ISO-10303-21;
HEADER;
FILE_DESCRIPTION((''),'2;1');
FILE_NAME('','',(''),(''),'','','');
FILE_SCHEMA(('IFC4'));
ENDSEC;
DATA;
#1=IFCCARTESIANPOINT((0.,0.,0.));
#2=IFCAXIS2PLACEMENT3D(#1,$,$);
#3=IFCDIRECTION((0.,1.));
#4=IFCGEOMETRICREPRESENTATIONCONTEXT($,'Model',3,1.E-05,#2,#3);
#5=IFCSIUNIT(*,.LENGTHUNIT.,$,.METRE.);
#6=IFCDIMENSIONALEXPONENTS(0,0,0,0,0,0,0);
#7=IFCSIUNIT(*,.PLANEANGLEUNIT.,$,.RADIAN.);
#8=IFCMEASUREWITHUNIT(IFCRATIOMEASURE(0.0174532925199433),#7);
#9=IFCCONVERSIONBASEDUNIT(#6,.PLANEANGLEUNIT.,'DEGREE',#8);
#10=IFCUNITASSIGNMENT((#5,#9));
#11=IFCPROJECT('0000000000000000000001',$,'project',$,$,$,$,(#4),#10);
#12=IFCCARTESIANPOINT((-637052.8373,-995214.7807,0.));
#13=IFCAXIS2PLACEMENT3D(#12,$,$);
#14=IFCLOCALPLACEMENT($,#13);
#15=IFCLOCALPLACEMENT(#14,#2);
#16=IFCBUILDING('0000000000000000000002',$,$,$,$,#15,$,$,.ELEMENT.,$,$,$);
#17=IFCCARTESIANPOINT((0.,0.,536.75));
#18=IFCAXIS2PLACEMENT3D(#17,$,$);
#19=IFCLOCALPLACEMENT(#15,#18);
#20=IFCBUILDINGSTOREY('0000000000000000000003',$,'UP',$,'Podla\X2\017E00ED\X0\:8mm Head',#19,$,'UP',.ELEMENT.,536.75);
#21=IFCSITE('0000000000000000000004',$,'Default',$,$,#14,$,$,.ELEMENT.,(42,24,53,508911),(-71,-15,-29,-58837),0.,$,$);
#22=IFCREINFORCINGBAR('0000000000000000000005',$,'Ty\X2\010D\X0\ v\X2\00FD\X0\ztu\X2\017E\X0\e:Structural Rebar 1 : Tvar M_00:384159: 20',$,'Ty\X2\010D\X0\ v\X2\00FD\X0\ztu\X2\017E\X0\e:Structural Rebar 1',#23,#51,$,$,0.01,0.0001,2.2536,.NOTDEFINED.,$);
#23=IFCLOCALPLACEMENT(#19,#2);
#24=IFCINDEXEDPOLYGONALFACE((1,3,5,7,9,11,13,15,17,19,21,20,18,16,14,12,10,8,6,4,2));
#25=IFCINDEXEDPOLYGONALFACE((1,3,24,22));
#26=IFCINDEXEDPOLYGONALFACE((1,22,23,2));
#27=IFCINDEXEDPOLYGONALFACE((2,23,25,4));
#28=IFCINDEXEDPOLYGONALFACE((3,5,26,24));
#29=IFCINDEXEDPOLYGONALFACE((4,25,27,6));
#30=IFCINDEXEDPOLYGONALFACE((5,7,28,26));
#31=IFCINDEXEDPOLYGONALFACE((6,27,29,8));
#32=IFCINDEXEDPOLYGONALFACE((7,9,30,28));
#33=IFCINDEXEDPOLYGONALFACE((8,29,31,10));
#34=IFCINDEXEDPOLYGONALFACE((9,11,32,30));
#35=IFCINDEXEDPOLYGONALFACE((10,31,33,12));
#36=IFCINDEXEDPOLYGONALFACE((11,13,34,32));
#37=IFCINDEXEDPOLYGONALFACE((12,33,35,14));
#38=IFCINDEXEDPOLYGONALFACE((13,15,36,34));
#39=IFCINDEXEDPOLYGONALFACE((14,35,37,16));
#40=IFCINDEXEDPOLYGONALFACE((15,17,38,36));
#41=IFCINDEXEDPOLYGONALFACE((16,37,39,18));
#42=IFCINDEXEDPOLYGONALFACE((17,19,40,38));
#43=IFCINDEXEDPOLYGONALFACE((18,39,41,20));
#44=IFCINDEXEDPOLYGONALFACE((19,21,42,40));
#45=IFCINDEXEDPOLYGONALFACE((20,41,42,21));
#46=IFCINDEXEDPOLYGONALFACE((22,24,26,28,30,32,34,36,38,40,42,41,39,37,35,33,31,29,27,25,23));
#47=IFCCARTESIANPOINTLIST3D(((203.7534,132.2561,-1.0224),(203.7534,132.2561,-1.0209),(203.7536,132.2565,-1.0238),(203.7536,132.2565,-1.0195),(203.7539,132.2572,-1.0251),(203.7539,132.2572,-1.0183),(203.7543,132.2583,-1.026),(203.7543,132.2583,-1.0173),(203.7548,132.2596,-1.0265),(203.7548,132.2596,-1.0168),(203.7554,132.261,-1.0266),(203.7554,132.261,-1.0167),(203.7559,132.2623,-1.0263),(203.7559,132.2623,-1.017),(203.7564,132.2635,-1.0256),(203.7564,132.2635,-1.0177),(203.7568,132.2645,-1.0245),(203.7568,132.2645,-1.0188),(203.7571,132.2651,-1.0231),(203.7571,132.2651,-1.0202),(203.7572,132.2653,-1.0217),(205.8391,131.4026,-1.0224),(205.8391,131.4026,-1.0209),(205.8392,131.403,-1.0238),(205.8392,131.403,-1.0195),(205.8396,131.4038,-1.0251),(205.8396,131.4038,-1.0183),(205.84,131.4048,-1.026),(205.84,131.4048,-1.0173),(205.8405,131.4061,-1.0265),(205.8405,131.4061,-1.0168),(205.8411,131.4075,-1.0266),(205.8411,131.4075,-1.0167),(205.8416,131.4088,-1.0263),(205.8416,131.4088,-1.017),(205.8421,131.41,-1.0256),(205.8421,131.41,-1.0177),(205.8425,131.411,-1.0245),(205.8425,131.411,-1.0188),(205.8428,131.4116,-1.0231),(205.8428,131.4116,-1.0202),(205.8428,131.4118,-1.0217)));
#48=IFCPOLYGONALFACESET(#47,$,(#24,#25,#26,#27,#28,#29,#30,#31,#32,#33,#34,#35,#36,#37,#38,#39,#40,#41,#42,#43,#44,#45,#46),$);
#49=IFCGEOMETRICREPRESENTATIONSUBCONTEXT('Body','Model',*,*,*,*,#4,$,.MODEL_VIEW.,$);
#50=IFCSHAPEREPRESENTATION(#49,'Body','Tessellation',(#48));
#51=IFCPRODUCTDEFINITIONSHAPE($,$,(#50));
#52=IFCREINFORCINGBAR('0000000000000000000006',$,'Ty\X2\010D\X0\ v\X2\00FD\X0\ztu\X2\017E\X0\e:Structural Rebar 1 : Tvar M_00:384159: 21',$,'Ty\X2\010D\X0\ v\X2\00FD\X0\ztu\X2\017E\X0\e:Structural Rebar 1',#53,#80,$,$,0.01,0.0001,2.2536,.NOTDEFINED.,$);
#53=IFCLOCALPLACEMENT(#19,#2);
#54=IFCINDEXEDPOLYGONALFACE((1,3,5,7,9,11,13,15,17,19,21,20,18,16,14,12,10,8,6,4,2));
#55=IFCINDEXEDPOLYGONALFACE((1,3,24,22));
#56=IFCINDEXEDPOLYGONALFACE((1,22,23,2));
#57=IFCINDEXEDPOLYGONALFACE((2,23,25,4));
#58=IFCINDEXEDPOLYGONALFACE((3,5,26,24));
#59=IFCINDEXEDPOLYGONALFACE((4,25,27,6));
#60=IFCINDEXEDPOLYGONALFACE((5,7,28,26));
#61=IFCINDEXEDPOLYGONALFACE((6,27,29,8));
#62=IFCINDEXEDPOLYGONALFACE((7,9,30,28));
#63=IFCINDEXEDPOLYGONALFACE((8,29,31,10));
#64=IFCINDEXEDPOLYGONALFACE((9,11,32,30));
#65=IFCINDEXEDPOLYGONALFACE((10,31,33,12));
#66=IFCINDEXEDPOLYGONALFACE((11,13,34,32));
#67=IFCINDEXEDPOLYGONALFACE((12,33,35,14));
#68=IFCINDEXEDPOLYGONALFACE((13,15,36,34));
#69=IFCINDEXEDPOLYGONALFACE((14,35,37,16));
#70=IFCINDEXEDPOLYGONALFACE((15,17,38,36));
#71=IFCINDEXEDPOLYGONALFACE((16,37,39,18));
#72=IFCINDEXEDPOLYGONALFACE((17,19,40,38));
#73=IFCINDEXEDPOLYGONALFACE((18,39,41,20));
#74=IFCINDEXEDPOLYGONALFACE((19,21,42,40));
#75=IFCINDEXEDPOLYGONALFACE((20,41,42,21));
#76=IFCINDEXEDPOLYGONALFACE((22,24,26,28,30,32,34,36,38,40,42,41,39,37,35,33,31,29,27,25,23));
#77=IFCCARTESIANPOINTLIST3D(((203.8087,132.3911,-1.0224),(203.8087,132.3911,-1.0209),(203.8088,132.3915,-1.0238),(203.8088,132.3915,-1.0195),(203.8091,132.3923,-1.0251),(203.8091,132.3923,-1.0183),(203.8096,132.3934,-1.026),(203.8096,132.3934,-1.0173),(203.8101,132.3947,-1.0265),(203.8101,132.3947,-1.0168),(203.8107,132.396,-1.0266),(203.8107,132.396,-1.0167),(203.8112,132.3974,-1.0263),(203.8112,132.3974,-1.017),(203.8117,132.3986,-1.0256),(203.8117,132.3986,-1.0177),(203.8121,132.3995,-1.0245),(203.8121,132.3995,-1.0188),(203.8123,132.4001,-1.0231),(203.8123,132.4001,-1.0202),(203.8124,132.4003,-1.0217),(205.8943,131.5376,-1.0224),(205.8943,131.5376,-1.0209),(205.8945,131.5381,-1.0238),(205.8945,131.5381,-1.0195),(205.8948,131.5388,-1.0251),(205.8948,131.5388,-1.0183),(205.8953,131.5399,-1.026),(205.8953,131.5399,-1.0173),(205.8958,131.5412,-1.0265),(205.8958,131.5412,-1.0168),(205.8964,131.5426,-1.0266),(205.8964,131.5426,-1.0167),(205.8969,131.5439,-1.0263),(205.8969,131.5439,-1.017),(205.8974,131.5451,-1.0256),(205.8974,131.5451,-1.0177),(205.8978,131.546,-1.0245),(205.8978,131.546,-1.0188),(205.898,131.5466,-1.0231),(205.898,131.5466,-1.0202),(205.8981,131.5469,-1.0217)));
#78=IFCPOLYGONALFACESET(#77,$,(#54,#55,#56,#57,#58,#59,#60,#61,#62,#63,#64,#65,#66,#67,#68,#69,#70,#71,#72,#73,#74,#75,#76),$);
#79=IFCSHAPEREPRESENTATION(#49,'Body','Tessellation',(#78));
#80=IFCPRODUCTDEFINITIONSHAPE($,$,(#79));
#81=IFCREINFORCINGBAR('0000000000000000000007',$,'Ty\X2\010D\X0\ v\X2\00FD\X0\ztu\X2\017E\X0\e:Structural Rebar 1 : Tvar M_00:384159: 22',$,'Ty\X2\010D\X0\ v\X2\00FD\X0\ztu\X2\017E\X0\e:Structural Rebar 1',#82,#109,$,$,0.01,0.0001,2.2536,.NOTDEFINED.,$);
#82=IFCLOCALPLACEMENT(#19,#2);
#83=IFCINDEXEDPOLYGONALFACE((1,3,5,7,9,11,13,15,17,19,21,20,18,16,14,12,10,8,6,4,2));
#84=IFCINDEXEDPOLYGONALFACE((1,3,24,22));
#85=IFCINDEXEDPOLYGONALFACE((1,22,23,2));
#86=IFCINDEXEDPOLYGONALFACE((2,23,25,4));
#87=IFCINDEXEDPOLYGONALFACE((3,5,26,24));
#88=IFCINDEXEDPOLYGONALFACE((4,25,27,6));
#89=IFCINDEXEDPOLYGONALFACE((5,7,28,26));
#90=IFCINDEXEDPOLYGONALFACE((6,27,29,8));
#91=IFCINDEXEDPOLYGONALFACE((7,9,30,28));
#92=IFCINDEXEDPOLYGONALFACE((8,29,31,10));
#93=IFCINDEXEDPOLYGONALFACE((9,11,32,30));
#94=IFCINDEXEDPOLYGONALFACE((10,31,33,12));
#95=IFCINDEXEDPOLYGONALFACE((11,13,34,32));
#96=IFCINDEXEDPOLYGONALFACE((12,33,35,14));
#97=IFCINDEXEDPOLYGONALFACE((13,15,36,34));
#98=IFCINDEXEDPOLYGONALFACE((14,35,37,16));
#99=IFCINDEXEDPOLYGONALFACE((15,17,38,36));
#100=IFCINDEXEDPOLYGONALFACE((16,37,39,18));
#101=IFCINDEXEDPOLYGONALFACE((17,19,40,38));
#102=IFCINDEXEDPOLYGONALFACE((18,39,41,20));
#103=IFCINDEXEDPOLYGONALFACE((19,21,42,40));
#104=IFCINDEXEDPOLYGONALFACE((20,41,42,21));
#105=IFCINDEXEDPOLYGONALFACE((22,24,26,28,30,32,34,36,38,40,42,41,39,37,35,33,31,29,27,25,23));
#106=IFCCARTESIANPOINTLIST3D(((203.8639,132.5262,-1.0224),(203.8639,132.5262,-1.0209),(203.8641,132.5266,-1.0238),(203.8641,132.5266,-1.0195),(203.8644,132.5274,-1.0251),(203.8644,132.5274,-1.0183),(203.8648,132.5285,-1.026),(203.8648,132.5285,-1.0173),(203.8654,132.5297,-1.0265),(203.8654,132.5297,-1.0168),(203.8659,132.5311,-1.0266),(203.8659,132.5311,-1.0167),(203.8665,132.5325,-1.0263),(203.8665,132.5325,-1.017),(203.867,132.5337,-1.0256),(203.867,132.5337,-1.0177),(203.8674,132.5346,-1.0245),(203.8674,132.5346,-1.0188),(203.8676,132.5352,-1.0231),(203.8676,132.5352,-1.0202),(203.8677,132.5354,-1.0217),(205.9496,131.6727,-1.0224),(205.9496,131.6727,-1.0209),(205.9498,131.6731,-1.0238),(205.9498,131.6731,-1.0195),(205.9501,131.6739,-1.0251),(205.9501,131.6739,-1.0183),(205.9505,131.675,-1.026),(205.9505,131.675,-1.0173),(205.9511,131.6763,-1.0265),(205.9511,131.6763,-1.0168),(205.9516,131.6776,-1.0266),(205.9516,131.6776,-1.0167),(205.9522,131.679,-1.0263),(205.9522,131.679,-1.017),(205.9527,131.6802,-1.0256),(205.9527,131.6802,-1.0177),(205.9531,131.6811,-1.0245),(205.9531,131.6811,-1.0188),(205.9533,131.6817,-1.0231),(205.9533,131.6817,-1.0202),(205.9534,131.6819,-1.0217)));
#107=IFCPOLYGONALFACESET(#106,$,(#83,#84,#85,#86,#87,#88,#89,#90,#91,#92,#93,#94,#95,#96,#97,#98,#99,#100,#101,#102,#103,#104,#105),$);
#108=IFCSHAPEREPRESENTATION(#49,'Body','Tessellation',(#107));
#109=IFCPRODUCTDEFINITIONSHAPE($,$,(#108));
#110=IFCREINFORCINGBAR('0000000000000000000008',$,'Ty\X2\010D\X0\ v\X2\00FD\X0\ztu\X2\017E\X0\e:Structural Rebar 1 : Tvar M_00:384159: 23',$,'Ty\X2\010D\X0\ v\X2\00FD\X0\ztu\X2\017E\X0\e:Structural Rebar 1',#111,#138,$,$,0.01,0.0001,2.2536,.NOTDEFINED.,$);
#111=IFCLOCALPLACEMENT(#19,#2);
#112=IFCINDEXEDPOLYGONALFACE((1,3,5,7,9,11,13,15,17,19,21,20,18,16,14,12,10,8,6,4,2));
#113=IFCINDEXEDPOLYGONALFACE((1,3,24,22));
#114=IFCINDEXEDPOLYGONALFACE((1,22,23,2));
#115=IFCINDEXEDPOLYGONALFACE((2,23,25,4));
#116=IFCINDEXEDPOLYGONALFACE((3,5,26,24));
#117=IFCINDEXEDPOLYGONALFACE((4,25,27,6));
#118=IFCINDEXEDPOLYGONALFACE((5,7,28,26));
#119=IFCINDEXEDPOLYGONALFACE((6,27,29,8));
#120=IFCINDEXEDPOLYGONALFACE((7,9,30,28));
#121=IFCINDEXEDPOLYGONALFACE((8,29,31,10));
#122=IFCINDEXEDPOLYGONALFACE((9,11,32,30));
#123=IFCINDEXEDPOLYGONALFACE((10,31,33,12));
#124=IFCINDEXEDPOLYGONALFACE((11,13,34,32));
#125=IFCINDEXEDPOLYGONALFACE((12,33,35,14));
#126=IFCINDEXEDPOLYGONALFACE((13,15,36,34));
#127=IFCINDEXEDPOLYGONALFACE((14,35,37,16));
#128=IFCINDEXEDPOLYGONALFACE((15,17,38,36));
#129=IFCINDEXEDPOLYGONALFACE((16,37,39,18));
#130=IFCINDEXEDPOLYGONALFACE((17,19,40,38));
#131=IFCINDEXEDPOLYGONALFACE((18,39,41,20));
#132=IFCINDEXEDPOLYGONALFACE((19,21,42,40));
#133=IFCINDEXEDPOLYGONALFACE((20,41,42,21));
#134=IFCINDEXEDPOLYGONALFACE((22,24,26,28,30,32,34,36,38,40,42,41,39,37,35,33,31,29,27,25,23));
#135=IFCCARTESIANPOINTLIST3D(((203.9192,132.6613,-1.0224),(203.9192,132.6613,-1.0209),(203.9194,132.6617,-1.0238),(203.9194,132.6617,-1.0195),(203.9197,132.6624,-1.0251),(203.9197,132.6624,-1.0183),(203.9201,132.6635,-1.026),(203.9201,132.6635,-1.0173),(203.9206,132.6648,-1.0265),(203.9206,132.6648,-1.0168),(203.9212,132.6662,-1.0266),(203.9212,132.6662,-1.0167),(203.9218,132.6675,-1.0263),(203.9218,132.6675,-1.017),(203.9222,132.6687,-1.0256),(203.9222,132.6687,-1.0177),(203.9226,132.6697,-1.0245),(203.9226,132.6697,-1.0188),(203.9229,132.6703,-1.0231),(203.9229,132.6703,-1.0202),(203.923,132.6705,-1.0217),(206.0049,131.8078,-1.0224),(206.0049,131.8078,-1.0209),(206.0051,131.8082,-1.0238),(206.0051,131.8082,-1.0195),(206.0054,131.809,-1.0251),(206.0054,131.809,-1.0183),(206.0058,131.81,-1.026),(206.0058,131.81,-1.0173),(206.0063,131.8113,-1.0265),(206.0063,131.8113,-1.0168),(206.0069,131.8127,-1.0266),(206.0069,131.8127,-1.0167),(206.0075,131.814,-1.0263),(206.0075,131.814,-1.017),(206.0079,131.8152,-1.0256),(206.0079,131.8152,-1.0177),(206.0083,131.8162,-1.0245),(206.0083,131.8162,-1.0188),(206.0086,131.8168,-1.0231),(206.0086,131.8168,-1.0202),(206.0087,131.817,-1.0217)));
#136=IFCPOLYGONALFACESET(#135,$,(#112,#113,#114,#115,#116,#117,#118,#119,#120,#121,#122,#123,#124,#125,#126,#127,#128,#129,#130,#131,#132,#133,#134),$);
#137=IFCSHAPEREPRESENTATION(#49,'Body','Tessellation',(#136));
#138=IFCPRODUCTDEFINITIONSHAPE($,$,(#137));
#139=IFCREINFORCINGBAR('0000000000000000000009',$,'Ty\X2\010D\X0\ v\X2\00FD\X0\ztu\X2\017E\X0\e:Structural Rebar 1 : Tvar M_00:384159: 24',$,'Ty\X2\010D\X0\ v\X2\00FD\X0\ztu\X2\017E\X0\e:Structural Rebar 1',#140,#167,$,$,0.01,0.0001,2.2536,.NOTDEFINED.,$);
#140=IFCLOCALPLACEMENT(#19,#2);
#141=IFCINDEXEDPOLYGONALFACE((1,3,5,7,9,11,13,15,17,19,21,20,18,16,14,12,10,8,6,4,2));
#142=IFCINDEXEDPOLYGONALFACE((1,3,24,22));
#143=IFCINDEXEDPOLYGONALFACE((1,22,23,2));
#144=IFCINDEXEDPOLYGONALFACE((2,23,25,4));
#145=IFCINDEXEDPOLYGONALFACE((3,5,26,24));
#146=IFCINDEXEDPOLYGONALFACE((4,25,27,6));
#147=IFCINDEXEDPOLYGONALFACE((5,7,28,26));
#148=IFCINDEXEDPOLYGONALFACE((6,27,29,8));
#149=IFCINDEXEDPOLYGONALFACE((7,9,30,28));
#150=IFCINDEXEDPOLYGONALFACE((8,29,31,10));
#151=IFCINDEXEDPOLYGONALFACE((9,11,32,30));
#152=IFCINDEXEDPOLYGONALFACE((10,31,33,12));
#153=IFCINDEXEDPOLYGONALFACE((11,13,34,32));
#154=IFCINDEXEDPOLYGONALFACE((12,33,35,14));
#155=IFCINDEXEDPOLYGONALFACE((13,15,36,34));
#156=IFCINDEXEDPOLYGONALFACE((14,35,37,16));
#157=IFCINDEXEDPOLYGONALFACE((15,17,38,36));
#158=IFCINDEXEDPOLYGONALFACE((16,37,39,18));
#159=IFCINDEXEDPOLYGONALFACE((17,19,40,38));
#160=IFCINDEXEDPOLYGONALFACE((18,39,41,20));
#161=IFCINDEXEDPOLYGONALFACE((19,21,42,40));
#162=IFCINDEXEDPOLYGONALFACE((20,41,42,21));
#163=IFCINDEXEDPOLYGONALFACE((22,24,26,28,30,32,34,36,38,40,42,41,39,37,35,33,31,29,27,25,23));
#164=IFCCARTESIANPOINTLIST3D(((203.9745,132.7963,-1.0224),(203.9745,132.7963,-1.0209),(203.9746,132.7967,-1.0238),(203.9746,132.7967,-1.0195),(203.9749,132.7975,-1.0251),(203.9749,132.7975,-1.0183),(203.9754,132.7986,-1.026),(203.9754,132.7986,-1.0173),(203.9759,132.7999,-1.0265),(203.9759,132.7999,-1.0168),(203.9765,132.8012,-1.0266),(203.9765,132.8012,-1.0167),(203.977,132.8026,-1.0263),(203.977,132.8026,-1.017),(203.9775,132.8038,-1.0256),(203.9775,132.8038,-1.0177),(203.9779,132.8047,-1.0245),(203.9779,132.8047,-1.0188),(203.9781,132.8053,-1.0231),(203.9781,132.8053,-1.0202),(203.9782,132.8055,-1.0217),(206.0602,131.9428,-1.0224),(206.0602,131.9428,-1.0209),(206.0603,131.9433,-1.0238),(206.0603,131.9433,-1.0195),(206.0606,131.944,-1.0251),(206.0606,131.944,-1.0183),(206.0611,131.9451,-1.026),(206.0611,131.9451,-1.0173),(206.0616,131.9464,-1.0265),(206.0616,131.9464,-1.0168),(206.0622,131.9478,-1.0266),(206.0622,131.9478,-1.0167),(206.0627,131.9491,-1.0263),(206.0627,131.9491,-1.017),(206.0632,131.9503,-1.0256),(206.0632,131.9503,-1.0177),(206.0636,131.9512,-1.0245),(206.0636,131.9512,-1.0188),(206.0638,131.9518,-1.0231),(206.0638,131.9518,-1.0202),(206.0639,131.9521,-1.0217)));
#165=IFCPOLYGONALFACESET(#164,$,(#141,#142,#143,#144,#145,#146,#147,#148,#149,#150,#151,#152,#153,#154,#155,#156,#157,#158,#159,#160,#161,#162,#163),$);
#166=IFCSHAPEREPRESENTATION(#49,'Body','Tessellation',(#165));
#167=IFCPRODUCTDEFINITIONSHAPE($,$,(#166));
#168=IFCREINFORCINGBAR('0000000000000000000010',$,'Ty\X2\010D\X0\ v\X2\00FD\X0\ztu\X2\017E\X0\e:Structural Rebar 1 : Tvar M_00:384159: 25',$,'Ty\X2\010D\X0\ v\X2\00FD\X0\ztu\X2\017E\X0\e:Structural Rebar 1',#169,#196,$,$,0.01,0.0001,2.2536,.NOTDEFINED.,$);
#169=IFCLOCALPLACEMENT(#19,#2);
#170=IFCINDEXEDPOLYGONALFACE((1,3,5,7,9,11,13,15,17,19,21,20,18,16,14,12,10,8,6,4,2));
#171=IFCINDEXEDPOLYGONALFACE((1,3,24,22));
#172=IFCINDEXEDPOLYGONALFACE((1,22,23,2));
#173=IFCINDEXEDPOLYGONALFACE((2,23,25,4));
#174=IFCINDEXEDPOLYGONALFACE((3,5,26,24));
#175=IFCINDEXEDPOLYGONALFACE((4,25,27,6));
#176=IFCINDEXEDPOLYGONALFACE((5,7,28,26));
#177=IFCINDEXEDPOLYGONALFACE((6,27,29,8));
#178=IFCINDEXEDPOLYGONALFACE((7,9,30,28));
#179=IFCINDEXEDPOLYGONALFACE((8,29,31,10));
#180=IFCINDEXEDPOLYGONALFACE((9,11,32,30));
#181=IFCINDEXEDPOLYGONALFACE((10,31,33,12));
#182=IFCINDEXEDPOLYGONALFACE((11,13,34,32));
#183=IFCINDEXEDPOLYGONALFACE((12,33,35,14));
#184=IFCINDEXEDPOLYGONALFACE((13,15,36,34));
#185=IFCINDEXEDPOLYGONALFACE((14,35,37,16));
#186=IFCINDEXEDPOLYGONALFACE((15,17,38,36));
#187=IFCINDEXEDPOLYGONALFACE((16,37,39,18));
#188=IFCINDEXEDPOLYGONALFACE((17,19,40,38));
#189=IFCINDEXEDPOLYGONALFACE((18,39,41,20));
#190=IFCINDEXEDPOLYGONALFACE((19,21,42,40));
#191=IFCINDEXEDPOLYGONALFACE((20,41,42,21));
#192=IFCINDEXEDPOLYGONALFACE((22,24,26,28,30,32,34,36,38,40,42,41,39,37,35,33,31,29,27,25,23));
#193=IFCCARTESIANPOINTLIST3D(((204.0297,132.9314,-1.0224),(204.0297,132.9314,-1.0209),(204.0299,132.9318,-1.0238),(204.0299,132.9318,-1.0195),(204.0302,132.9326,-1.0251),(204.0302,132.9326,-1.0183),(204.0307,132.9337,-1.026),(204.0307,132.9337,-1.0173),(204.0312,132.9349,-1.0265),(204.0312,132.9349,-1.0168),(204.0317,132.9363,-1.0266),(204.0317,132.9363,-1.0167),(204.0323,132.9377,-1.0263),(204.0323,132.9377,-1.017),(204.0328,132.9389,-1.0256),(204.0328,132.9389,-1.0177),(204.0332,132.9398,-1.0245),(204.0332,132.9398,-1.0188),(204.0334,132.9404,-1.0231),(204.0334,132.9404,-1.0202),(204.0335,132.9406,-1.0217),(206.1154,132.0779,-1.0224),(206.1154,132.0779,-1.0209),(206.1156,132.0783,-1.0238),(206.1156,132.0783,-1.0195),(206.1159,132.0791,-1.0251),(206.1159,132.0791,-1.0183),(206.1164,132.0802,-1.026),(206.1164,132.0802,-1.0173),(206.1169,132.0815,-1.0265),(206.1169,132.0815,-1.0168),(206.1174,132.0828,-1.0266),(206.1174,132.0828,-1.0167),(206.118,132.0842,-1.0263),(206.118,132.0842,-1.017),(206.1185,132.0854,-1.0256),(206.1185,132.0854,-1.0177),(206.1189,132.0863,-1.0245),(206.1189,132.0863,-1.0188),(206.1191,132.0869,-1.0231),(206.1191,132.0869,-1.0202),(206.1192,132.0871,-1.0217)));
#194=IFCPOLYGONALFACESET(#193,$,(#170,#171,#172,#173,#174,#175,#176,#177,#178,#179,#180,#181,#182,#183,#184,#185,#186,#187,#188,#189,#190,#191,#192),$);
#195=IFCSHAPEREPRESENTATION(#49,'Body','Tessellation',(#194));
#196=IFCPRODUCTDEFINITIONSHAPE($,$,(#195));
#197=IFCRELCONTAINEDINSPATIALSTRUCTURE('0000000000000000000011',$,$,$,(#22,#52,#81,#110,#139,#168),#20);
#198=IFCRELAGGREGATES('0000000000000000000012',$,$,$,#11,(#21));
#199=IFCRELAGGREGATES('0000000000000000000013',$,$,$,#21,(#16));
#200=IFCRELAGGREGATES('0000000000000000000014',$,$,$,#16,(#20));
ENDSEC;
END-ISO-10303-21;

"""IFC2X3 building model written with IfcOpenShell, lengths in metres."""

from ifc_helpers import new_model, entity, si_unit, converted_unit, direction, frame, origin, place, context, subcontext, project, spatial, element, save


model = new_model("IFC2X3")

# Units and contexts
model_context = context("Model", 3, precision=1e-05, world=origin(), true_north=direction((0.0, 1.0)))
body_context = subcontext(model_context, "Body", "Model", "MODEL_VIEW")
ifc_project = project(units=[si_unit("LENGTHUNIT", "METRE"), converted_unit("PLANEANGLEUNIT", "DEGREE", entity("IfcRatioMeasure", 0.0174532925199433), si_unit("PLANEANGLEUNIT", "RADIAN"), dimensions=[0, 0, 0, 0, 0, 0, 0])], contexts=[model_context])

# Site, building, storey
site_placement = place(None, frame((-637052.8373, -995214.7807, 0.0)))
site = spatial("IfcSite", under=ifc_project, at=site_placement, Name="Default", CompositionType="ELEMENT", RefLatitude=(42, 24, 53, 508911), RefLongitude=(-71, -15, -29, -58837), RefElevation=0.0)
building_placement = place(site_placement, origin())
building = spatial("IfcBuilding", under=site, at=building_placement, CompositionType="ELEMENT")
storey_placement = place(building_placement, frame((0.0, 0.0, 536.75)))
storey = spatial("IfcBuildingStorey", under=building, at=storey_placement, Name="UP", ObjectType="Podlaží:8mm Head", LongName="UP", CompositionType="ELEMENT", Elevation=536.75)

# Reinforcing bars
reinforcing_bar_1_placement = place(storey_placement, origin())
element("IfcReinforcingBar", 1, at=reinforcing_bar_1_placement, inside=storey, Name="Tyč výztuže:Structural Rebar 1 : Tvar M_00:384159: 20", ObjectType="Tyč výztuže:Structural Rebar 1", BarLength=2.2536, BarRole="NOTDEFINED", CrossSectionArea=0.0001, NominalDiameter=0.01, context=body_context, shape_type="AdvancedSweptSolid", body=[
    entity("IfcSweptDiskSolid", entity("IfcCompositeCurve", [entity("IfcCompositeCurveSegment", "CONTINUOUS", True, entity("IfcPolyline", [entity("IfcCartesianPoint", [-205.841, -131.4072, 1.0217]), entity("IfcCartesianPoint", [-203.7553, -132.2606, 1.0217])]))], False), 0.005, None, 0.0, 1.0),
])
reinforcing_bar_2_placement = place(storey_placement, origin())
element("IfcReinforcingBar", 2, at=reinforcing_bar_2_placement, inside=storey, Name="Tyč výztuže:Structural Rebar 1 : Tvar M_00:384159: 21", ObjectType="Tyč výztuže:Structural Rebar 1", BarLength=2.2536, BarRole="NOTDEFINED", CrossSectionArea=0.0001, NominalDiameter=0.01, context=body_context, shape_type="AdvancedSweptSolid", body=[
    entity("IfcSweptDiskSolid", entity("IfcCompositeCurve", [entity("IfcCompositeCurveSegment", "CONTINUOUS", True, entity("IfcPolyline", [entity("IfcCartesianPoint", [-205.8962, -131.5422, 1.0217]), entity("IfcCartesianPoint", [-203.8105, -132.3957, 1.0217])]))], False), 0.005, None, 0.0, 1.0),
])
reinforcing_bar_3_placement = place(storey_placement, origin())
element("IfcReinforcingBar", 3, at=reinforcing_bar_3_placement, inside=storey, Name="Tyč výztuže:Structural Rebar 1 : Tvar M_00:384159: 22", ObjectType="Tyč výztuže:Structural Rebar 1", BarLength=2.2536, BarRole="NOTDEFINED", CrossSectionArea=0.0001, NominalDiameter=0.01, context=body_context, shape_type="AdvancedSweptSolid", body=[
    entity("IfcSweptDiskSolid", entity("IfcCompositeCurve", [entity("IfcCompositeCurveSegment", "CONTINUOUS", True, entity("IfcPolyline", [entity("IfcCartesianPoint", [-205.9515, -131.6773, 1.0217]), entity("IfcCartesianPoint", [-203.8658, -132.5308, 1.0217])]))], False), 0.005, None, 0.0, 1.0),
])
reinforcing_bar_4_placement = place(storey_placement, origin())
element("IfcReinforcingBar", 4, at=reinforcing_bar_4_placement, inside=storey, Name="Tyč výztuže:Structural Rebar 1 : Tvar M_00:384159: 23", ObjectType="Tyč výztuže:Structural Rebar 1", BarLength=2.2536, BarRole="NOTDEFINED", CrossSectionArea=0.0001, NominalDiameter=0.01, context=body_context, shape_type="AdvancedSweptSolid", body=[
    entity("IfcSweptDiskSolid", entity("IfcCompositeCurve", [entity("IfcCompositeCurveSegment", "CONTINUOUS", True, entity("IfcPolyline", [entity("IfcCartesianPoint", [-206.0068, -131.8124, 1.0217]), entity("IfcCartesianPoint", [-203.9211, -132.6658, 1.0217])]))], False), 0.005, None, 0.0, 1.0),
])
reinforcing_bar_5_placement = place(storey_placement, origin())
element("IfcReinforcingBar", 5, at=reinforcing_bar_5_placement, inside=storey, Name="Tyč výztuže:Structural Rebar 1 : Tvar M_00:384159: 24", ObjectType="Tyč výztuže:Structural Rebar 1", BarLength=2.2536, BarRole="NOTDEFINED", CrossSectionArea=0.0001, NominalDiameter=0.01, context=body_context, shape_type="AdvancedSweptSolid", body=[
    entity("IfcSweptDiskSolid", entity("IfcCompositeCurve", [entity("IfcCompositeCurveSegment", "CONTINUOUS", True, entity("IfcPolyline", [entity("IfcCartesianPoint", [-206.062, -131.9474, 1.0217]), entity("IfcCartesianPoint", [-203.9763, -132.8009, 1.0217])]))], False), 0.005, None, 0.0, 1.0),
])
reinforcing_bar_6_placement = place(storey_placement, origin())
element("IfcReinforcingBar", 6, at=reinforcing_bar_6_placement, inside=storey, Name="Tyč výztuže:Structural Rebar 1 : Tvar M_00:384159: 25", ObjectType="Tyč výztuže:Structural Rebar 1", BarLength=2.2536, BarRole="NOTDEFINED", CrossSectionArea=0.0001, NominalDiameter=0.01, context=body_context, shape_type="AdvancedSweptSolid", body=[
    entity("IfcSweptDiskSolid", entity("IfcCompositeCurve", [entity("IfcCompositeCurveSegment", "CONTINUOUS", True, entity("IfcPolyline", [entity("IfcCartesianPoint", [-206.1173, -132.0825, 1.0217]), entity("IfcCartesianPoint", [-204.0316, -132.936, 1.0217])]))], False), 0.005, None, 0.0, 1.0),
])

save(model, "model.ifc")
